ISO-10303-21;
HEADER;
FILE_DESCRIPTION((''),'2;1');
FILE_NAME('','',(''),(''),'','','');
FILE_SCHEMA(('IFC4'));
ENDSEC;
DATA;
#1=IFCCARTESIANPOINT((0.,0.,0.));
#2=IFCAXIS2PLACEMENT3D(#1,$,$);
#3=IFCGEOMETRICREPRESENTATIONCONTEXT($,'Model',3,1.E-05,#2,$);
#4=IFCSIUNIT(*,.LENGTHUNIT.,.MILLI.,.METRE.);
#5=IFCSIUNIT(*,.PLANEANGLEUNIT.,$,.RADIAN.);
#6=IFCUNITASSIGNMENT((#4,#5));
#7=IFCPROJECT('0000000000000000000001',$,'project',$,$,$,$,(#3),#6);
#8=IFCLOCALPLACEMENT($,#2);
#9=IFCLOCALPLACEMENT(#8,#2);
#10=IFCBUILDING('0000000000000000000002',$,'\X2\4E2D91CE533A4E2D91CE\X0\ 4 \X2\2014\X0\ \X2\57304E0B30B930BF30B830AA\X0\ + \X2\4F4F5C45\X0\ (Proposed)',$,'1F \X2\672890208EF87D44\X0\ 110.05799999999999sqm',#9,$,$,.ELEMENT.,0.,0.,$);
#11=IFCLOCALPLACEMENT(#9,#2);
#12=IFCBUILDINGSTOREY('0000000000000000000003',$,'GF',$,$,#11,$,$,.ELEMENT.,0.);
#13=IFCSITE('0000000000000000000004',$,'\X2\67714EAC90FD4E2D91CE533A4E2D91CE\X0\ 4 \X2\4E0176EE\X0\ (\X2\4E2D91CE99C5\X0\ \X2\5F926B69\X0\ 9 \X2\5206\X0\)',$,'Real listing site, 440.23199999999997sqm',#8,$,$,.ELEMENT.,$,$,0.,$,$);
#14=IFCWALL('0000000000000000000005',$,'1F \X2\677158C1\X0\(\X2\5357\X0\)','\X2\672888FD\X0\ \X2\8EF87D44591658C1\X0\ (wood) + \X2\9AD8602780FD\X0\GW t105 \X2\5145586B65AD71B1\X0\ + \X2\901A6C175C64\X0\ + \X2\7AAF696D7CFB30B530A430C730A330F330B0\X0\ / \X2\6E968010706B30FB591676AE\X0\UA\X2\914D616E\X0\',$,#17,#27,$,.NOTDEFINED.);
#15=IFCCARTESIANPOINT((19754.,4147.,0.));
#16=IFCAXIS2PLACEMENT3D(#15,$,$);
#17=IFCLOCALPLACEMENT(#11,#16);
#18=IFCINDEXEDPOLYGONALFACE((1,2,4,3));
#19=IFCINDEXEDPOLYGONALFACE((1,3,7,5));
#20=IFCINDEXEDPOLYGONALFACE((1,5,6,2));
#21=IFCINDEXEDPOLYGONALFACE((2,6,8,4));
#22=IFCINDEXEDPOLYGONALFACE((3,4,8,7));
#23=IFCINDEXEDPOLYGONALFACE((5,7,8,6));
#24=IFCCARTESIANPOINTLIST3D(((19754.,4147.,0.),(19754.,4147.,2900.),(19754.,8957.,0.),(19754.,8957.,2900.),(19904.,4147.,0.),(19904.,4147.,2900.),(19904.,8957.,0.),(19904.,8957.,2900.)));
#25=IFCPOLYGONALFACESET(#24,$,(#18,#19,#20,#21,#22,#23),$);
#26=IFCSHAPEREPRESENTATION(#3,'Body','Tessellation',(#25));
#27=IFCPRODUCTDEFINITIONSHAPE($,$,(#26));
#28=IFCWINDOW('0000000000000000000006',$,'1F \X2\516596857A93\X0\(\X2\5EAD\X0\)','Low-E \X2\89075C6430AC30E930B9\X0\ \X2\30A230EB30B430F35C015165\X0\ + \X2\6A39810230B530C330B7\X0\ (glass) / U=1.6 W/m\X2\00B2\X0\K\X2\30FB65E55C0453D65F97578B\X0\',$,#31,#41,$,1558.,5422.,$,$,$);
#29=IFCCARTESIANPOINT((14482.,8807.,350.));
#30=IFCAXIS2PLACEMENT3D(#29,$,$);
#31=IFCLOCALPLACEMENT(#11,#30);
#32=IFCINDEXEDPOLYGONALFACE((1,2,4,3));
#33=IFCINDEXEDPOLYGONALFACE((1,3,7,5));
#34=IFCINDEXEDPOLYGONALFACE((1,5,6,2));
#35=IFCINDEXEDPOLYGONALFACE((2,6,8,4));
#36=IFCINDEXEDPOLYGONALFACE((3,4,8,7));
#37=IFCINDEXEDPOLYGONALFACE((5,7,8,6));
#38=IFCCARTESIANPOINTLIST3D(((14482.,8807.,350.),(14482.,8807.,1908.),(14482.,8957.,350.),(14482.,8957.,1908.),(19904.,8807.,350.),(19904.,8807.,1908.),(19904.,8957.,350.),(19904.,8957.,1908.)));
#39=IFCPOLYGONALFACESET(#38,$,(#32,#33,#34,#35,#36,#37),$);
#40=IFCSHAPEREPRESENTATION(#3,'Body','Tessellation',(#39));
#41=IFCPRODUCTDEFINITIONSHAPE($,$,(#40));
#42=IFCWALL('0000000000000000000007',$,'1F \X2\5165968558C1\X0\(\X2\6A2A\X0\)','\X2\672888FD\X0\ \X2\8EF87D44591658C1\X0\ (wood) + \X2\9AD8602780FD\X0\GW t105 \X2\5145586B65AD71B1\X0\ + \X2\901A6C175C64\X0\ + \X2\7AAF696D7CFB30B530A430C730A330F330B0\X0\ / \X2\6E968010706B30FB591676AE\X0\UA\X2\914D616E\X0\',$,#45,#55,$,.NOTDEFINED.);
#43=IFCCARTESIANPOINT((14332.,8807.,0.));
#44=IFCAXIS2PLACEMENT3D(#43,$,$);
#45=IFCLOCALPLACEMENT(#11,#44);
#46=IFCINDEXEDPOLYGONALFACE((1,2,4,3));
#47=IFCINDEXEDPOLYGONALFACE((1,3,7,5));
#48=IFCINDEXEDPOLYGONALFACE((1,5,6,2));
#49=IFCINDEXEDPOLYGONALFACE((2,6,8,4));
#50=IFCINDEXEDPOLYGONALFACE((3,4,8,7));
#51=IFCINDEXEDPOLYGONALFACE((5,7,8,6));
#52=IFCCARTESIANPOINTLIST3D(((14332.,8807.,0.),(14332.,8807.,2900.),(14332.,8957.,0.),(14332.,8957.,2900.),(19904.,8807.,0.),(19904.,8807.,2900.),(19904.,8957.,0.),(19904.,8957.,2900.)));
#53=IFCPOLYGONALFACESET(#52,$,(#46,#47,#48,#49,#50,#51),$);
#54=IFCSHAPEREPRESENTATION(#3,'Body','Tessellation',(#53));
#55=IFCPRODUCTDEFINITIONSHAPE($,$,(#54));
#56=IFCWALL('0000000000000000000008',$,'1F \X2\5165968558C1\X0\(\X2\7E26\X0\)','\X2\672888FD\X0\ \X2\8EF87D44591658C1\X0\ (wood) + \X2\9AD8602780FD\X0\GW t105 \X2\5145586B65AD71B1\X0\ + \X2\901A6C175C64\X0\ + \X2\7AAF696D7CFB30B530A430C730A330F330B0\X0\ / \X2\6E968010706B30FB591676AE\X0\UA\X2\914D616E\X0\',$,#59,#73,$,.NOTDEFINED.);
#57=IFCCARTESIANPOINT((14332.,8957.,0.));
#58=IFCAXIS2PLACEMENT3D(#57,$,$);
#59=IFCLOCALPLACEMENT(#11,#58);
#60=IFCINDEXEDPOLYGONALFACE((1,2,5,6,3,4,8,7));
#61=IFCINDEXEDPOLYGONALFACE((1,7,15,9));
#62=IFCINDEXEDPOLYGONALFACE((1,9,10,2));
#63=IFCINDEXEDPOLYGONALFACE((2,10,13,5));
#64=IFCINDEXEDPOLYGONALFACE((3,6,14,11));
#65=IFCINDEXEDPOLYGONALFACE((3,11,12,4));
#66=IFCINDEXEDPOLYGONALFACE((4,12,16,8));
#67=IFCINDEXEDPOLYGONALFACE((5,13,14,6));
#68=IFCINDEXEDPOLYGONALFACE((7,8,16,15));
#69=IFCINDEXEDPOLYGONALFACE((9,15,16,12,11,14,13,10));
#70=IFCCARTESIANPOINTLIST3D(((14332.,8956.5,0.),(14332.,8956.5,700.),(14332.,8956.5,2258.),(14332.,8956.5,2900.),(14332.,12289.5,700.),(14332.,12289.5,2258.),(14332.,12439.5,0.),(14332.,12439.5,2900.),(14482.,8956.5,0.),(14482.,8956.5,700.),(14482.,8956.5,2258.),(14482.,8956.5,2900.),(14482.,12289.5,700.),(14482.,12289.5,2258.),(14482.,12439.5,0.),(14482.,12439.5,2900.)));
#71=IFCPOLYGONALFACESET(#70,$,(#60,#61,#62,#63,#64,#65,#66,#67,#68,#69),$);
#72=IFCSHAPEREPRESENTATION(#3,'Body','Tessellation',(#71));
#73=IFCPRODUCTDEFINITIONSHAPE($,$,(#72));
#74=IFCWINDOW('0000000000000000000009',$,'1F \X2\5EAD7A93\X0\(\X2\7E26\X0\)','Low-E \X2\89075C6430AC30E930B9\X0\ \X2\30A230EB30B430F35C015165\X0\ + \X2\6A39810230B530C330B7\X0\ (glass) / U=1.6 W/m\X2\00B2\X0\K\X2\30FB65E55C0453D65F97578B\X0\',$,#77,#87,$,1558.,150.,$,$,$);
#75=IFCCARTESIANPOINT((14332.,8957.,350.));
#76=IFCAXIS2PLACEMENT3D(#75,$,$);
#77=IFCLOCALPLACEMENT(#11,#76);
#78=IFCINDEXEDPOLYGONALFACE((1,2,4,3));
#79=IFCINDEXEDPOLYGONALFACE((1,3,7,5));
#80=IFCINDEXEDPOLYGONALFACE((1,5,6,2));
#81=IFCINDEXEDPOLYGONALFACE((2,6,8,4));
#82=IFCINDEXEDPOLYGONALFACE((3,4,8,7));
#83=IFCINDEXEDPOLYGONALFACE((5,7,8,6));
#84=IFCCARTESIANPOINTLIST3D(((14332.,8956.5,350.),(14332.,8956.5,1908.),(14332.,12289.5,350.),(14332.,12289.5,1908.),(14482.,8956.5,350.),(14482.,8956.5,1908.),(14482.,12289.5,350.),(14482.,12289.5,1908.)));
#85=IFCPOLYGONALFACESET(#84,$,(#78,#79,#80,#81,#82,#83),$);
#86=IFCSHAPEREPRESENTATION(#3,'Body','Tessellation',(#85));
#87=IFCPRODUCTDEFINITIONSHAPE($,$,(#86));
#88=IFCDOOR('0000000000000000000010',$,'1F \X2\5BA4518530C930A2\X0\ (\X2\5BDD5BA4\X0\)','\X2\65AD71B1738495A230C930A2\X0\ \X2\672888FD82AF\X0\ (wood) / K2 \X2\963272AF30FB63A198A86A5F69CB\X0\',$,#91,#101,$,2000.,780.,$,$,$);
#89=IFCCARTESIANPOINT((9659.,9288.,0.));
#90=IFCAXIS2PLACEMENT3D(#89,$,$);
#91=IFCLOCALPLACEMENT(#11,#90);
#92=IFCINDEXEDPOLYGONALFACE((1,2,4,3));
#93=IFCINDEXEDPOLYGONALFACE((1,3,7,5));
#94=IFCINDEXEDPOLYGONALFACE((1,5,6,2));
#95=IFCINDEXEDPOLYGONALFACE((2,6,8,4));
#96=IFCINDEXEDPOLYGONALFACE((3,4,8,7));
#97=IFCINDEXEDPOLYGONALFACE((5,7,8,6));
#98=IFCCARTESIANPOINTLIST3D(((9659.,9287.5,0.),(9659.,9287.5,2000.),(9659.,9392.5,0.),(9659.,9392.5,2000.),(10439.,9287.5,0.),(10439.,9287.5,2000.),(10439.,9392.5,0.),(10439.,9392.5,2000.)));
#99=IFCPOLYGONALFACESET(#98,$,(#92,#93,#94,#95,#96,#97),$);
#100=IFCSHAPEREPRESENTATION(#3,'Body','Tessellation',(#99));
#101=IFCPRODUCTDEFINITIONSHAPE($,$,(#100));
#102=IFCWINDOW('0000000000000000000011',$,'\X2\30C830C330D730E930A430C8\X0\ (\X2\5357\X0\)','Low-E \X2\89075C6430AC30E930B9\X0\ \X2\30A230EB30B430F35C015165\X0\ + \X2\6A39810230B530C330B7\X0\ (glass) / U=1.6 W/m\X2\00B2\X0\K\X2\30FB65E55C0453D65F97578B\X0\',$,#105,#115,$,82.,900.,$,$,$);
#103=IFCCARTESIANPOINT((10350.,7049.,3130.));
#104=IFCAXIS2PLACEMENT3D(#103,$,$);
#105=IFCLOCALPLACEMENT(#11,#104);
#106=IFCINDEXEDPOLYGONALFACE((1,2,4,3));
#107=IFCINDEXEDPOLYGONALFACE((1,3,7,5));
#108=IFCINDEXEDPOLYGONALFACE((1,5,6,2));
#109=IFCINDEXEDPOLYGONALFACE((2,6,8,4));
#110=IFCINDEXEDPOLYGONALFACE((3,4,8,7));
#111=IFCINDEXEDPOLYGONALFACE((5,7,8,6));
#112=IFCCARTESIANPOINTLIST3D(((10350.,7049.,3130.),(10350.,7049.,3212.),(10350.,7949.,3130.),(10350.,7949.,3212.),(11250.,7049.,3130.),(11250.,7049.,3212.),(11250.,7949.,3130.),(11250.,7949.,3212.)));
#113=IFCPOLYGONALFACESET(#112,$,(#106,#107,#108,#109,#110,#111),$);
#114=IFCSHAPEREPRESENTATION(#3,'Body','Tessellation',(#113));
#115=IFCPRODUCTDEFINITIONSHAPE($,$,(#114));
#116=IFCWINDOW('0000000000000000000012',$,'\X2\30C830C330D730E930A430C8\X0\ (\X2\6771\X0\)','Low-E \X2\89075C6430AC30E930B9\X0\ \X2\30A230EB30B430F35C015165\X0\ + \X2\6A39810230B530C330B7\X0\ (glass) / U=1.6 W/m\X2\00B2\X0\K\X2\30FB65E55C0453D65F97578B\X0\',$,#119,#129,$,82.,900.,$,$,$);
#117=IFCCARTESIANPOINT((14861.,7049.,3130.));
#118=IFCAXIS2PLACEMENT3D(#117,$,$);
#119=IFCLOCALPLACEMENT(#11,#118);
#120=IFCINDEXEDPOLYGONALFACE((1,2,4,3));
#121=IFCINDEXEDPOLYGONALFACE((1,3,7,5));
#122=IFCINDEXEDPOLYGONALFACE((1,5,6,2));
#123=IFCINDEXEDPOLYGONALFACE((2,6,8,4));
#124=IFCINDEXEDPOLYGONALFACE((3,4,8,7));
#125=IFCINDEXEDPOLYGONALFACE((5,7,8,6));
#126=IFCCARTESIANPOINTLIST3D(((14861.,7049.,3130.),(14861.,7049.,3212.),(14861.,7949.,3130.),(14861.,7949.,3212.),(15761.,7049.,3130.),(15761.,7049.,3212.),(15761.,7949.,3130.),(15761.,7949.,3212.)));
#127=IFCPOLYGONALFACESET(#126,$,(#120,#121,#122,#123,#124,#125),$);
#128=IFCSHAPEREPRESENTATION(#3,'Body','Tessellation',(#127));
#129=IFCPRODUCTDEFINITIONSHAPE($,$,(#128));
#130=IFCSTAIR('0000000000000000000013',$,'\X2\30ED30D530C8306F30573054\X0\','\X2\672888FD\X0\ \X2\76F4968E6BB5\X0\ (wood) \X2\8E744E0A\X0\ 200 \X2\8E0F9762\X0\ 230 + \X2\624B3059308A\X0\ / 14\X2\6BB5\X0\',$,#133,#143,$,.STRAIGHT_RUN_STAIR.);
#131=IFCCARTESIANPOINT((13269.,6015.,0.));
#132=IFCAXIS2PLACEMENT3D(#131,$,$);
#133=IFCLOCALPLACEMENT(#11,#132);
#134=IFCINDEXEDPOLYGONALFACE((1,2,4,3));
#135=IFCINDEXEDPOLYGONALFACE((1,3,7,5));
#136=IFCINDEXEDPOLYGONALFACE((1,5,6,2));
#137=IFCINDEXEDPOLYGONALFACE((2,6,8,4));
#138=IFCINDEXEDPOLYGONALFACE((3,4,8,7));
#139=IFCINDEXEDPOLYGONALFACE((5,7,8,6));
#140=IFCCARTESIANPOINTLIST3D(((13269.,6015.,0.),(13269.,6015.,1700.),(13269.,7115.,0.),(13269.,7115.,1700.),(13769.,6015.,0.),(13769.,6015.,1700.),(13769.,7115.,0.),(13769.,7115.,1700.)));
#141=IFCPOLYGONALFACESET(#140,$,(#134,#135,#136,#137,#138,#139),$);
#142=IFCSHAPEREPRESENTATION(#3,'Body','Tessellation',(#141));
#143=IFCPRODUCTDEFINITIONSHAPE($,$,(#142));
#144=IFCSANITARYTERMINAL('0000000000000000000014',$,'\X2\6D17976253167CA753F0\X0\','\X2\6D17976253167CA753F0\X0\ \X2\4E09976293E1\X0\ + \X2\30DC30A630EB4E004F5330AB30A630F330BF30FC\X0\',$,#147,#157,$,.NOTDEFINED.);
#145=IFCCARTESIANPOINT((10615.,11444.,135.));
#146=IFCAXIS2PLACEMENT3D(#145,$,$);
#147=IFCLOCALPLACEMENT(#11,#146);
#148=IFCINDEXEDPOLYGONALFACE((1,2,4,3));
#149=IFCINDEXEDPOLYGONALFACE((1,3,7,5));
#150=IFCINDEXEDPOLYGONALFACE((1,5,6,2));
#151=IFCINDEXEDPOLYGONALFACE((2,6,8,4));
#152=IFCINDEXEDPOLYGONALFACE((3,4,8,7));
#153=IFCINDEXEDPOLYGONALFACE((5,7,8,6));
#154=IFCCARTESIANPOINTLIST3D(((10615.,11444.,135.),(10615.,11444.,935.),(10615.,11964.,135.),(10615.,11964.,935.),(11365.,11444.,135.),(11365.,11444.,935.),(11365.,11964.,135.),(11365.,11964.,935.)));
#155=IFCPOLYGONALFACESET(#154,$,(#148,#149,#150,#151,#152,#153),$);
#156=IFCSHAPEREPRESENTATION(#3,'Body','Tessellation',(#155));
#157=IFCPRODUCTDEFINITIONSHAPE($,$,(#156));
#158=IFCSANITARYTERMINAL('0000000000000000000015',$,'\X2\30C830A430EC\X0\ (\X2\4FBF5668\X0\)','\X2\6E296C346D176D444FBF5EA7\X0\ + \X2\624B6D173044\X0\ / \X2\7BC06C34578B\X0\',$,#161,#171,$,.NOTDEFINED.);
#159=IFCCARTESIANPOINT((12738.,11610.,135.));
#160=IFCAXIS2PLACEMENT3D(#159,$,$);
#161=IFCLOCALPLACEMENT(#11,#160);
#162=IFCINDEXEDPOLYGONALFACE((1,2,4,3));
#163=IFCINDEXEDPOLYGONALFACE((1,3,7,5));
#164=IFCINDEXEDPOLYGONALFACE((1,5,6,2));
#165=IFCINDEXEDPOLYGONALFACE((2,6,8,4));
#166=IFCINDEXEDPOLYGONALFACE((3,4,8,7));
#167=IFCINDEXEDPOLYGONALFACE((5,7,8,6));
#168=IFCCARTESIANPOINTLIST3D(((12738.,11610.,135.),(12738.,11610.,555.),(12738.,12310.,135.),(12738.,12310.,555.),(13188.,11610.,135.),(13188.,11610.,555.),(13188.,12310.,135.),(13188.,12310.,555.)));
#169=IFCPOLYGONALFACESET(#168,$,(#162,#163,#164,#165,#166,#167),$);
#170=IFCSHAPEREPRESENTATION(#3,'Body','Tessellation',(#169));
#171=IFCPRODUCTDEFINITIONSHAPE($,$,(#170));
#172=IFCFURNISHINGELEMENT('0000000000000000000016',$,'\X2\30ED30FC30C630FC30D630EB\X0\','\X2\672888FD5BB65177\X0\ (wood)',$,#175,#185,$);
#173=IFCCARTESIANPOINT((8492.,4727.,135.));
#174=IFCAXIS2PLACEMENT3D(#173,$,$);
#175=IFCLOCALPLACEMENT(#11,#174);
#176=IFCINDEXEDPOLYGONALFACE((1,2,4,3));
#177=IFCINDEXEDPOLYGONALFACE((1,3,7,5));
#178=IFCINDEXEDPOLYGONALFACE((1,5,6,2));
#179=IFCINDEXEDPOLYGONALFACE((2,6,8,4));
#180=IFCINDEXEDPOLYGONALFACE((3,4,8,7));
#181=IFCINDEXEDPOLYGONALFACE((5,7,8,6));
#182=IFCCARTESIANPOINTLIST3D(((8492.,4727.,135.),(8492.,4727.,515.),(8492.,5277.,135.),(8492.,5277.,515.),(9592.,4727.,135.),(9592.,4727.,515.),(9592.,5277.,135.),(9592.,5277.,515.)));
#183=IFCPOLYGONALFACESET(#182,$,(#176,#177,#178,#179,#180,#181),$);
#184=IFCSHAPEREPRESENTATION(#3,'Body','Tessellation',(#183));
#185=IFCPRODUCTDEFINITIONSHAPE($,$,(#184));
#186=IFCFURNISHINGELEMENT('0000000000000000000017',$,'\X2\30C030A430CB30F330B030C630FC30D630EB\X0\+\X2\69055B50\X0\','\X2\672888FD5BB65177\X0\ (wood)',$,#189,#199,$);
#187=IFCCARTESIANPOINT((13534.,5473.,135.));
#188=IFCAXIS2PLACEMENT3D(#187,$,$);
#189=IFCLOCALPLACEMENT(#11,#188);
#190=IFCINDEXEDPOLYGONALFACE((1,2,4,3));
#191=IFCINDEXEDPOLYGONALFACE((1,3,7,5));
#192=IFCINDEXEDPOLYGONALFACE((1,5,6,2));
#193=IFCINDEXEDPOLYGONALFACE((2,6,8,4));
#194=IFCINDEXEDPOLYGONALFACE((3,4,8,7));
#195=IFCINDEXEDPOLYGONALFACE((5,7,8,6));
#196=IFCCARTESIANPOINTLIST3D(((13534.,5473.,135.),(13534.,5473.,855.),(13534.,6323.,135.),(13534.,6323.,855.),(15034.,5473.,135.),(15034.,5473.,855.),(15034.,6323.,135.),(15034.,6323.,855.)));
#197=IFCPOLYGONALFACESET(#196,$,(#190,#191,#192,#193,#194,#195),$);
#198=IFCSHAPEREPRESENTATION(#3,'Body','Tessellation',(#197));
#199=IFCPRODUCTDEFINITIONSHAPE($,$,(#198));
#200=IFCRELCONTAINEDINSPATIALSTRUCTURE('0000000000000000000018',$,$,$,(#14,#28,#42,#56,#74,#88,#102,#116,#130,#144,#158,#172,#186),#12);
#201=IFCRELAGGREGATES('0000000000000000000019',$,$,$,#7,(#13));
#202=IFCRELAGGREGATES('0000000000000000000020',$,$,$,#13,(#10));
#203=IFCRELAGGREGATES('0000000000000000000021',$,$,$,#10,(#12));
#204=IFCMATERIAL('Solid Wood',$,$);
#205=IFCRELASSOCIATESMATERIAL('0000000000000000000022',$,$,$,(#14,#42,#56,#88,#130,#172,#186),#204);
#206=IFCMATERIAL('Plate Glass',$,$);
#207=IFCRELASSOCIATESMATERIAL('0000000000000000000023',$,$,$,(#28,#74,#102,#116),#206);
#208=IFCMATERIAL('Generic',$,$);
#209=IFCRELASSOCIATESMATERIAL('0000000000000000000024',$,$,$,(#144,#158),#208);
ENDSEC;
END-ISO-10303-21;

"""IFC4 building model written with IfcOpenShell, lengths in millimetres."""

from ifc_helpers import new_model, si_unit, frame, frame_2d, origin, place, context, project, spatial, rectangle, extrude, material, element, fill, save


model = new_model("IFC4")

# Units and contexts
model_context = context("Model", 3, precision=1e-05, world=origin())
ifc_project = project(units=[si_unit("LENGTHUNIT", "METRE", prefix="MILLI"), si_unit("PLANEANGLEUNIT", "RADIAN")], contexts=[model_context])

# Site, building, storey
site_placement = place(None, origin())
site = spatial("IfcSite", under=ifc_project, at=site_placement, Name="東京都中野区中野 4 丁目 (中野駅 徒歩 9 分)", ObjectType="Real listing site, 440.23199999999997sqm", CompositionType="ELEMENT", RefElevation=0.0)
building_placement = place(site_placement, origin())
building = spatial("IfcBuilding", under=site, at=building_placement, Name="中野区中野 4 — 地下スタジオ + 住居 (Proposed)", ObjectType="1F 木造軸組 110.05799999999999sqm", CompositionType="ELEMENT", ElevationOfRefHeight=0.0, ElevationOfTerrain=0.0)
storey_placement = place(building_placement, origin())
storey = spatial("IfcBuildingStorey", under=building, at=storey_placement, Name="GF", CompositionType="ELEMENT", Elevation=0.0)

# Shared definitions
ifc_material_1 = material(Name="Solid Wood")

# Wall, opening, window
wall_1_placement = place(storey_placement, frame((19754.0, 4147.0, 0.0)))
wall_1 = element("IfcWall", 1, at=wall_1_placement, inside=storey, material=ifc_material_1, Name="1F 東壁(南)", Description="木製 軸組外壁 (wood) + 高性能GW t105 充填断熱 + 通気層 + 窯業系サイディング / 準耐火・外皮UA配慮", PredefinedType="NOTDEFINED", context=model_context, shape_type="SweptSolid", body=[
    extrude(rectangle(XDim=150.0, YDim=4810.0, at=frame_2d((75.0, 2405.0))), frame((19754.0, 4147.0, 0.0)), (0.0, 0.0, 1.0), 2900.0),
])
opening_1_placement = place(storey_placement, frame((14482.0, 8807.0, 350.0)))
opening_1 = element("IfcOpeningElement", 2, at=opening_1_placement, cuts=wall_1, PredefinedType="NOTDEFINED", context=model_context, shape_type="SweptSolid", body=[
    extrude(rectangle(XDim=5422.0, YDim=150.0, at=frame_2d((2711.0, 75.0))), frame((14482.0, 8807.0, 350.0)), (0.0, 0.0, 1.0), 1558.0),
])
ifc_material_2 = material(Name="Plate Glass")
window_1_placement = place(storey_placement, frame((14482.0, 8807.0, 350.0)))
window_1 = element("IfcWindow", 3, at=window_1_placement, inside=storey, material=ifc_material_2, Name="1F 入隅窓(庭)", Description="Low-E 複層ガラス アルゴン封入 + 樹脂サッシ (glass) / U=1.6 W/m²K・日射取得型", OverallHeight=1558.0, OverallWidth=5422.0, context=model_context, shape_type="SweptSolid", body=[
    extrude(rectangle(XDim=5422.0, YDim=150.0, at=frame_2d((2711.0, 75.0))), frame((14482.0, 8807.0, 350.0)), (0.0, 0.0, 1.0), 1558.0),
])
fill(opening_1, window_1)

# Wall
wall_2_placement = place(storey_placement, frame((14332.0, 8807.0, 0.0)))
element("IfcWall", 4, at=wall_2_placement, inside=storey, material=ifc_material_1, Name="1F 入隅壁(横)", Description="木製 軸組外壁 (wood) + 高性能GW t105 充填断熱 + 通気層 + 窯業系サイディング / 準耐火・外皮UA配慮", PredefinedType="NOTDEFINED", context=model_context, shape_type="SweptSolid", body=[
    extrude(rectangle(XDim=5572.0, YDim=150.0, at=frame_2d((2786.0, 75.0))), frame((14332.0, 8807.0, 0.0)), (0.0, 0.0, 1.0), 2900.0),
])

# Wall, opening, window
wall_3_placement = place(storey_placement, frame((14332.0, 8957.0, 0.0)))
wall_3 = element("IfcWall", 5, at=wall_3_placement, inside=storey, material=ifc_material_1, Name="1F 入隅壁(縦)", Description="木製 軸組外壁 (wood) + 高性能GW t105 充填断熱 + 通気層 + 窯業系サイディング / 準耐火・外皮UA配慮", PredefinedType="NOTDEFINED", context=model_context, shape_type="SweptSolid", body=[
    extrude(rectangle(XDim=150.0, YDim=3483.0, at=frame_2d((75.0, 1741.0))), frame((14332.0, 8957.0, 0.0)), (0.0, 0.0, 1.0), 2900.0),
])
opening_2_placement = place(storey_placement, frame((14332.0, 8957.0, 350.0)))
opening_2 = element("IfcOpeningElement", 6, at=opening_2_placement, cuts=wall_3, PredefinedType="NOTDEFINED", context=model_context, shape_type="SweptSolid", body=[
    extrude(rectangle(XDim=150.0, YDim=3333.0, at=frame_2d((75.0, 1666.0))), frame((14332.0, 8957.0, 350.0)), (0.0, 0.0, 1.0), 1558.0),
])
window_2_placement = place(storey_placement, frame((14332.0, 8957.0, 350.0)))
window_2 = element("IfcWindow", 7, at=window_2_placement, inside=storey, material=ifc_material_2, Name="1F 庭窓(縦)", Description="Low-E 複層ガラス アルゴン封入 + 樹脂サッシ (glass) / U=1.6 W/m²K・日射取得型", OverallHeight=1558.0, OverallWidth=150.0, context=model_context, shape_type="SweptSolid", body=[
    extrude(rectangle(XDim=150.0, YDim=3333.0, at=frame_2d((75.0, 1666.0))), frame((14332.0, 8957.0, 350.0)), (0.0, 0.0, 1.0), 1558.0),
])
fill(opening_2, window_2)

# Door
door_placement = place(storey_placement, frame((9659.0, 9288.0, 0.0)))
element("IfcDoor", 8, at=door_placement, inside=storey, material=ifc_material_1, Name="1F 室内ドア (寝室)", Description="断熱玄関ドア 木製芯 (wood) / K2 防犯・採風機構", OverallHeight=2000.0, OverallWidth=780.0, context=model_context, shape_type="SweptSolid", body=[
    extrude(rectangle(XDim=780.0, YDim=105.0, at=frame_2d((390.0, 52.0))), frame((9659.0, 9288.0, 0.0)), (0.0, 0.0, 1.0), 2000.0),
])

# Windows
window_3_placement = place(storey_placement, frame((10350.0, 7049.0, 3130.0)))
element("IfcWindow", 9, at=window_3_placement, inside=storey, material=ifc_material_2, Name="トップライト (南)", Description="Low-E 複層ガラス アルゴン封入 + 樹脂サッシ (glass) / U=1.6 W/m²K・日射取得型", OverallHeight=82.0, OverallWidth=900.0, context=model_context, shape_type="SweptSolid", body=[
    extrude(rectangle(XDim=900.0, YDim=900.0, at=frame_2d((450.0, 450.0))), frame((10350.0, 7049.0, 3130.0)), (0.0, 0.0, 1.0), 82.0),
])
window_4_placement = place(storey_placement, frame((14861.0, 7049.0, 3130.0)))
element("IfcWindow", 10, at=window_4_placement, inside=storey, material=ifc_material_2, Name="トップライト (東)", Description="Low-E 複層ガラス アルゴン封入 + 樹脂サッシ (glass) / U=1.6 W/m²K・日射取得型", OverallHeight=82.0, OverallWidth=900.0, context=model_context, shape_type="SweptSolid", body=[
    extrude(rectangle(XDim=900.0, YDim=900.0, at=frame_2d((450.0, 450.0))), frame((14861.0, 7049.0, 3130.0)), (0.0, 0.0, 1.0), 82.0),
])

# Stair
stair_placement = place(storey_placement, frame((13269.0, 6015.0, 0.0)))
element("IfcStair", 11, at=stair_placement, inside=storey, material=ifc_material_1, Name="ロフトはしご", Description="木製 直階段 (wood) 蹴上 200 踏面 230 + 手すり / 14段", PredefinedType="STRAIGHT_RUN_STAIR", context=model_context, shape_type="SweptSolid", body=[
    extrude(rectangle(XDim=500.0, YDim=1100.0, at=frame_2d((250.0, 550.0))), frame((13269.0, 6015.0, 0.0)), (0.0, 0.0, 1.0), 1700.0),
])

# Sanitary terminals
ifc_material_3 = material(Name="Generic")
sanitary_terminal_1_placement = place(storey_placement, frame((10615.0, 11444.0, 135.0)))
element("IfcSanitaryTerminal", 12, at=sanitary_terminal_1_placement, inside=storey, material=ifc_material_3, Name="洗面化粧台", Description="洗面化粧台 三面鏡 + ボウル一体カウンター", PredefinedType="NOTDEFINED", context=model_context, shape_type="SweptSolid", body=[
    extrude(rectangle(XDim=750.0, YDim=520.0, at=frame_2d((375.0, 260.0))), frame((10615.0, 11444.0, 135.0)), (0.0, 0.0, 1.0), 800.0),
])
sanitary_terminal_2_placement = place(storey_placement, frame((12738.0, 11610.0, 135.0)))
element("IfcSanitaryTerminal", 13, at=sanitary_terminal_2_placement, inside=storey, material=ifc_material_3, Name="トイレ (便器)", Description="温水洗浄便座 + 手洗い / 節水型", PredefinedType="NOTDEFINED", context=model_context, shape_type="SweptSolid", body=[
    extrude(rectangle(XDim=450.0, YDim=700.0, at=frame_2d((225.0, 350.0))), frame((12738.0, 11610.0, 135.0)), (0.0, 0.0, 1.0), 420.0),
])

# Furnishing elements
furnishing_1_placement = place(storey_placement, frame((8492.0, 4727.0, 135.0)))
element("IfcFurnishingElement", 14, at=furnishing_1_placement, inside=storey, material=ifc_material_1, Name="ローテーブル", Description="木製家具 (wood)", context=model_context, shape_type="SweptSolid", body=[
    extrude(rectangle(XDim=1100.0, YDim=550.0, at=frame_2d((550.0, 275.0))), frame((8492.0, 4727.0, 135.0)), (0.0, 0.0, 1.0), 380.0),
])
furnishing_2_placement = place(storey_placement, frame((13534.0, 5473.0, 135.0)))
element("IfcFurnishingElement", 15, at=furnishing_2_placement, inside=storey, material=ifc_material_1, Name="ダイニングテーブル+椅子", Description="木製家具 (wood)", context=model_context, shape_type="SweptSolid", body=[
    extrude(rectangle(XDim=1500.0, YDim=850.0, at=frame_2d((750.0, 425.0))), frame((13534.0, 5473.0, 135.0)), (0.0, 0.0, 1.0), 720.0),
])

save(model, "model.ifc")
